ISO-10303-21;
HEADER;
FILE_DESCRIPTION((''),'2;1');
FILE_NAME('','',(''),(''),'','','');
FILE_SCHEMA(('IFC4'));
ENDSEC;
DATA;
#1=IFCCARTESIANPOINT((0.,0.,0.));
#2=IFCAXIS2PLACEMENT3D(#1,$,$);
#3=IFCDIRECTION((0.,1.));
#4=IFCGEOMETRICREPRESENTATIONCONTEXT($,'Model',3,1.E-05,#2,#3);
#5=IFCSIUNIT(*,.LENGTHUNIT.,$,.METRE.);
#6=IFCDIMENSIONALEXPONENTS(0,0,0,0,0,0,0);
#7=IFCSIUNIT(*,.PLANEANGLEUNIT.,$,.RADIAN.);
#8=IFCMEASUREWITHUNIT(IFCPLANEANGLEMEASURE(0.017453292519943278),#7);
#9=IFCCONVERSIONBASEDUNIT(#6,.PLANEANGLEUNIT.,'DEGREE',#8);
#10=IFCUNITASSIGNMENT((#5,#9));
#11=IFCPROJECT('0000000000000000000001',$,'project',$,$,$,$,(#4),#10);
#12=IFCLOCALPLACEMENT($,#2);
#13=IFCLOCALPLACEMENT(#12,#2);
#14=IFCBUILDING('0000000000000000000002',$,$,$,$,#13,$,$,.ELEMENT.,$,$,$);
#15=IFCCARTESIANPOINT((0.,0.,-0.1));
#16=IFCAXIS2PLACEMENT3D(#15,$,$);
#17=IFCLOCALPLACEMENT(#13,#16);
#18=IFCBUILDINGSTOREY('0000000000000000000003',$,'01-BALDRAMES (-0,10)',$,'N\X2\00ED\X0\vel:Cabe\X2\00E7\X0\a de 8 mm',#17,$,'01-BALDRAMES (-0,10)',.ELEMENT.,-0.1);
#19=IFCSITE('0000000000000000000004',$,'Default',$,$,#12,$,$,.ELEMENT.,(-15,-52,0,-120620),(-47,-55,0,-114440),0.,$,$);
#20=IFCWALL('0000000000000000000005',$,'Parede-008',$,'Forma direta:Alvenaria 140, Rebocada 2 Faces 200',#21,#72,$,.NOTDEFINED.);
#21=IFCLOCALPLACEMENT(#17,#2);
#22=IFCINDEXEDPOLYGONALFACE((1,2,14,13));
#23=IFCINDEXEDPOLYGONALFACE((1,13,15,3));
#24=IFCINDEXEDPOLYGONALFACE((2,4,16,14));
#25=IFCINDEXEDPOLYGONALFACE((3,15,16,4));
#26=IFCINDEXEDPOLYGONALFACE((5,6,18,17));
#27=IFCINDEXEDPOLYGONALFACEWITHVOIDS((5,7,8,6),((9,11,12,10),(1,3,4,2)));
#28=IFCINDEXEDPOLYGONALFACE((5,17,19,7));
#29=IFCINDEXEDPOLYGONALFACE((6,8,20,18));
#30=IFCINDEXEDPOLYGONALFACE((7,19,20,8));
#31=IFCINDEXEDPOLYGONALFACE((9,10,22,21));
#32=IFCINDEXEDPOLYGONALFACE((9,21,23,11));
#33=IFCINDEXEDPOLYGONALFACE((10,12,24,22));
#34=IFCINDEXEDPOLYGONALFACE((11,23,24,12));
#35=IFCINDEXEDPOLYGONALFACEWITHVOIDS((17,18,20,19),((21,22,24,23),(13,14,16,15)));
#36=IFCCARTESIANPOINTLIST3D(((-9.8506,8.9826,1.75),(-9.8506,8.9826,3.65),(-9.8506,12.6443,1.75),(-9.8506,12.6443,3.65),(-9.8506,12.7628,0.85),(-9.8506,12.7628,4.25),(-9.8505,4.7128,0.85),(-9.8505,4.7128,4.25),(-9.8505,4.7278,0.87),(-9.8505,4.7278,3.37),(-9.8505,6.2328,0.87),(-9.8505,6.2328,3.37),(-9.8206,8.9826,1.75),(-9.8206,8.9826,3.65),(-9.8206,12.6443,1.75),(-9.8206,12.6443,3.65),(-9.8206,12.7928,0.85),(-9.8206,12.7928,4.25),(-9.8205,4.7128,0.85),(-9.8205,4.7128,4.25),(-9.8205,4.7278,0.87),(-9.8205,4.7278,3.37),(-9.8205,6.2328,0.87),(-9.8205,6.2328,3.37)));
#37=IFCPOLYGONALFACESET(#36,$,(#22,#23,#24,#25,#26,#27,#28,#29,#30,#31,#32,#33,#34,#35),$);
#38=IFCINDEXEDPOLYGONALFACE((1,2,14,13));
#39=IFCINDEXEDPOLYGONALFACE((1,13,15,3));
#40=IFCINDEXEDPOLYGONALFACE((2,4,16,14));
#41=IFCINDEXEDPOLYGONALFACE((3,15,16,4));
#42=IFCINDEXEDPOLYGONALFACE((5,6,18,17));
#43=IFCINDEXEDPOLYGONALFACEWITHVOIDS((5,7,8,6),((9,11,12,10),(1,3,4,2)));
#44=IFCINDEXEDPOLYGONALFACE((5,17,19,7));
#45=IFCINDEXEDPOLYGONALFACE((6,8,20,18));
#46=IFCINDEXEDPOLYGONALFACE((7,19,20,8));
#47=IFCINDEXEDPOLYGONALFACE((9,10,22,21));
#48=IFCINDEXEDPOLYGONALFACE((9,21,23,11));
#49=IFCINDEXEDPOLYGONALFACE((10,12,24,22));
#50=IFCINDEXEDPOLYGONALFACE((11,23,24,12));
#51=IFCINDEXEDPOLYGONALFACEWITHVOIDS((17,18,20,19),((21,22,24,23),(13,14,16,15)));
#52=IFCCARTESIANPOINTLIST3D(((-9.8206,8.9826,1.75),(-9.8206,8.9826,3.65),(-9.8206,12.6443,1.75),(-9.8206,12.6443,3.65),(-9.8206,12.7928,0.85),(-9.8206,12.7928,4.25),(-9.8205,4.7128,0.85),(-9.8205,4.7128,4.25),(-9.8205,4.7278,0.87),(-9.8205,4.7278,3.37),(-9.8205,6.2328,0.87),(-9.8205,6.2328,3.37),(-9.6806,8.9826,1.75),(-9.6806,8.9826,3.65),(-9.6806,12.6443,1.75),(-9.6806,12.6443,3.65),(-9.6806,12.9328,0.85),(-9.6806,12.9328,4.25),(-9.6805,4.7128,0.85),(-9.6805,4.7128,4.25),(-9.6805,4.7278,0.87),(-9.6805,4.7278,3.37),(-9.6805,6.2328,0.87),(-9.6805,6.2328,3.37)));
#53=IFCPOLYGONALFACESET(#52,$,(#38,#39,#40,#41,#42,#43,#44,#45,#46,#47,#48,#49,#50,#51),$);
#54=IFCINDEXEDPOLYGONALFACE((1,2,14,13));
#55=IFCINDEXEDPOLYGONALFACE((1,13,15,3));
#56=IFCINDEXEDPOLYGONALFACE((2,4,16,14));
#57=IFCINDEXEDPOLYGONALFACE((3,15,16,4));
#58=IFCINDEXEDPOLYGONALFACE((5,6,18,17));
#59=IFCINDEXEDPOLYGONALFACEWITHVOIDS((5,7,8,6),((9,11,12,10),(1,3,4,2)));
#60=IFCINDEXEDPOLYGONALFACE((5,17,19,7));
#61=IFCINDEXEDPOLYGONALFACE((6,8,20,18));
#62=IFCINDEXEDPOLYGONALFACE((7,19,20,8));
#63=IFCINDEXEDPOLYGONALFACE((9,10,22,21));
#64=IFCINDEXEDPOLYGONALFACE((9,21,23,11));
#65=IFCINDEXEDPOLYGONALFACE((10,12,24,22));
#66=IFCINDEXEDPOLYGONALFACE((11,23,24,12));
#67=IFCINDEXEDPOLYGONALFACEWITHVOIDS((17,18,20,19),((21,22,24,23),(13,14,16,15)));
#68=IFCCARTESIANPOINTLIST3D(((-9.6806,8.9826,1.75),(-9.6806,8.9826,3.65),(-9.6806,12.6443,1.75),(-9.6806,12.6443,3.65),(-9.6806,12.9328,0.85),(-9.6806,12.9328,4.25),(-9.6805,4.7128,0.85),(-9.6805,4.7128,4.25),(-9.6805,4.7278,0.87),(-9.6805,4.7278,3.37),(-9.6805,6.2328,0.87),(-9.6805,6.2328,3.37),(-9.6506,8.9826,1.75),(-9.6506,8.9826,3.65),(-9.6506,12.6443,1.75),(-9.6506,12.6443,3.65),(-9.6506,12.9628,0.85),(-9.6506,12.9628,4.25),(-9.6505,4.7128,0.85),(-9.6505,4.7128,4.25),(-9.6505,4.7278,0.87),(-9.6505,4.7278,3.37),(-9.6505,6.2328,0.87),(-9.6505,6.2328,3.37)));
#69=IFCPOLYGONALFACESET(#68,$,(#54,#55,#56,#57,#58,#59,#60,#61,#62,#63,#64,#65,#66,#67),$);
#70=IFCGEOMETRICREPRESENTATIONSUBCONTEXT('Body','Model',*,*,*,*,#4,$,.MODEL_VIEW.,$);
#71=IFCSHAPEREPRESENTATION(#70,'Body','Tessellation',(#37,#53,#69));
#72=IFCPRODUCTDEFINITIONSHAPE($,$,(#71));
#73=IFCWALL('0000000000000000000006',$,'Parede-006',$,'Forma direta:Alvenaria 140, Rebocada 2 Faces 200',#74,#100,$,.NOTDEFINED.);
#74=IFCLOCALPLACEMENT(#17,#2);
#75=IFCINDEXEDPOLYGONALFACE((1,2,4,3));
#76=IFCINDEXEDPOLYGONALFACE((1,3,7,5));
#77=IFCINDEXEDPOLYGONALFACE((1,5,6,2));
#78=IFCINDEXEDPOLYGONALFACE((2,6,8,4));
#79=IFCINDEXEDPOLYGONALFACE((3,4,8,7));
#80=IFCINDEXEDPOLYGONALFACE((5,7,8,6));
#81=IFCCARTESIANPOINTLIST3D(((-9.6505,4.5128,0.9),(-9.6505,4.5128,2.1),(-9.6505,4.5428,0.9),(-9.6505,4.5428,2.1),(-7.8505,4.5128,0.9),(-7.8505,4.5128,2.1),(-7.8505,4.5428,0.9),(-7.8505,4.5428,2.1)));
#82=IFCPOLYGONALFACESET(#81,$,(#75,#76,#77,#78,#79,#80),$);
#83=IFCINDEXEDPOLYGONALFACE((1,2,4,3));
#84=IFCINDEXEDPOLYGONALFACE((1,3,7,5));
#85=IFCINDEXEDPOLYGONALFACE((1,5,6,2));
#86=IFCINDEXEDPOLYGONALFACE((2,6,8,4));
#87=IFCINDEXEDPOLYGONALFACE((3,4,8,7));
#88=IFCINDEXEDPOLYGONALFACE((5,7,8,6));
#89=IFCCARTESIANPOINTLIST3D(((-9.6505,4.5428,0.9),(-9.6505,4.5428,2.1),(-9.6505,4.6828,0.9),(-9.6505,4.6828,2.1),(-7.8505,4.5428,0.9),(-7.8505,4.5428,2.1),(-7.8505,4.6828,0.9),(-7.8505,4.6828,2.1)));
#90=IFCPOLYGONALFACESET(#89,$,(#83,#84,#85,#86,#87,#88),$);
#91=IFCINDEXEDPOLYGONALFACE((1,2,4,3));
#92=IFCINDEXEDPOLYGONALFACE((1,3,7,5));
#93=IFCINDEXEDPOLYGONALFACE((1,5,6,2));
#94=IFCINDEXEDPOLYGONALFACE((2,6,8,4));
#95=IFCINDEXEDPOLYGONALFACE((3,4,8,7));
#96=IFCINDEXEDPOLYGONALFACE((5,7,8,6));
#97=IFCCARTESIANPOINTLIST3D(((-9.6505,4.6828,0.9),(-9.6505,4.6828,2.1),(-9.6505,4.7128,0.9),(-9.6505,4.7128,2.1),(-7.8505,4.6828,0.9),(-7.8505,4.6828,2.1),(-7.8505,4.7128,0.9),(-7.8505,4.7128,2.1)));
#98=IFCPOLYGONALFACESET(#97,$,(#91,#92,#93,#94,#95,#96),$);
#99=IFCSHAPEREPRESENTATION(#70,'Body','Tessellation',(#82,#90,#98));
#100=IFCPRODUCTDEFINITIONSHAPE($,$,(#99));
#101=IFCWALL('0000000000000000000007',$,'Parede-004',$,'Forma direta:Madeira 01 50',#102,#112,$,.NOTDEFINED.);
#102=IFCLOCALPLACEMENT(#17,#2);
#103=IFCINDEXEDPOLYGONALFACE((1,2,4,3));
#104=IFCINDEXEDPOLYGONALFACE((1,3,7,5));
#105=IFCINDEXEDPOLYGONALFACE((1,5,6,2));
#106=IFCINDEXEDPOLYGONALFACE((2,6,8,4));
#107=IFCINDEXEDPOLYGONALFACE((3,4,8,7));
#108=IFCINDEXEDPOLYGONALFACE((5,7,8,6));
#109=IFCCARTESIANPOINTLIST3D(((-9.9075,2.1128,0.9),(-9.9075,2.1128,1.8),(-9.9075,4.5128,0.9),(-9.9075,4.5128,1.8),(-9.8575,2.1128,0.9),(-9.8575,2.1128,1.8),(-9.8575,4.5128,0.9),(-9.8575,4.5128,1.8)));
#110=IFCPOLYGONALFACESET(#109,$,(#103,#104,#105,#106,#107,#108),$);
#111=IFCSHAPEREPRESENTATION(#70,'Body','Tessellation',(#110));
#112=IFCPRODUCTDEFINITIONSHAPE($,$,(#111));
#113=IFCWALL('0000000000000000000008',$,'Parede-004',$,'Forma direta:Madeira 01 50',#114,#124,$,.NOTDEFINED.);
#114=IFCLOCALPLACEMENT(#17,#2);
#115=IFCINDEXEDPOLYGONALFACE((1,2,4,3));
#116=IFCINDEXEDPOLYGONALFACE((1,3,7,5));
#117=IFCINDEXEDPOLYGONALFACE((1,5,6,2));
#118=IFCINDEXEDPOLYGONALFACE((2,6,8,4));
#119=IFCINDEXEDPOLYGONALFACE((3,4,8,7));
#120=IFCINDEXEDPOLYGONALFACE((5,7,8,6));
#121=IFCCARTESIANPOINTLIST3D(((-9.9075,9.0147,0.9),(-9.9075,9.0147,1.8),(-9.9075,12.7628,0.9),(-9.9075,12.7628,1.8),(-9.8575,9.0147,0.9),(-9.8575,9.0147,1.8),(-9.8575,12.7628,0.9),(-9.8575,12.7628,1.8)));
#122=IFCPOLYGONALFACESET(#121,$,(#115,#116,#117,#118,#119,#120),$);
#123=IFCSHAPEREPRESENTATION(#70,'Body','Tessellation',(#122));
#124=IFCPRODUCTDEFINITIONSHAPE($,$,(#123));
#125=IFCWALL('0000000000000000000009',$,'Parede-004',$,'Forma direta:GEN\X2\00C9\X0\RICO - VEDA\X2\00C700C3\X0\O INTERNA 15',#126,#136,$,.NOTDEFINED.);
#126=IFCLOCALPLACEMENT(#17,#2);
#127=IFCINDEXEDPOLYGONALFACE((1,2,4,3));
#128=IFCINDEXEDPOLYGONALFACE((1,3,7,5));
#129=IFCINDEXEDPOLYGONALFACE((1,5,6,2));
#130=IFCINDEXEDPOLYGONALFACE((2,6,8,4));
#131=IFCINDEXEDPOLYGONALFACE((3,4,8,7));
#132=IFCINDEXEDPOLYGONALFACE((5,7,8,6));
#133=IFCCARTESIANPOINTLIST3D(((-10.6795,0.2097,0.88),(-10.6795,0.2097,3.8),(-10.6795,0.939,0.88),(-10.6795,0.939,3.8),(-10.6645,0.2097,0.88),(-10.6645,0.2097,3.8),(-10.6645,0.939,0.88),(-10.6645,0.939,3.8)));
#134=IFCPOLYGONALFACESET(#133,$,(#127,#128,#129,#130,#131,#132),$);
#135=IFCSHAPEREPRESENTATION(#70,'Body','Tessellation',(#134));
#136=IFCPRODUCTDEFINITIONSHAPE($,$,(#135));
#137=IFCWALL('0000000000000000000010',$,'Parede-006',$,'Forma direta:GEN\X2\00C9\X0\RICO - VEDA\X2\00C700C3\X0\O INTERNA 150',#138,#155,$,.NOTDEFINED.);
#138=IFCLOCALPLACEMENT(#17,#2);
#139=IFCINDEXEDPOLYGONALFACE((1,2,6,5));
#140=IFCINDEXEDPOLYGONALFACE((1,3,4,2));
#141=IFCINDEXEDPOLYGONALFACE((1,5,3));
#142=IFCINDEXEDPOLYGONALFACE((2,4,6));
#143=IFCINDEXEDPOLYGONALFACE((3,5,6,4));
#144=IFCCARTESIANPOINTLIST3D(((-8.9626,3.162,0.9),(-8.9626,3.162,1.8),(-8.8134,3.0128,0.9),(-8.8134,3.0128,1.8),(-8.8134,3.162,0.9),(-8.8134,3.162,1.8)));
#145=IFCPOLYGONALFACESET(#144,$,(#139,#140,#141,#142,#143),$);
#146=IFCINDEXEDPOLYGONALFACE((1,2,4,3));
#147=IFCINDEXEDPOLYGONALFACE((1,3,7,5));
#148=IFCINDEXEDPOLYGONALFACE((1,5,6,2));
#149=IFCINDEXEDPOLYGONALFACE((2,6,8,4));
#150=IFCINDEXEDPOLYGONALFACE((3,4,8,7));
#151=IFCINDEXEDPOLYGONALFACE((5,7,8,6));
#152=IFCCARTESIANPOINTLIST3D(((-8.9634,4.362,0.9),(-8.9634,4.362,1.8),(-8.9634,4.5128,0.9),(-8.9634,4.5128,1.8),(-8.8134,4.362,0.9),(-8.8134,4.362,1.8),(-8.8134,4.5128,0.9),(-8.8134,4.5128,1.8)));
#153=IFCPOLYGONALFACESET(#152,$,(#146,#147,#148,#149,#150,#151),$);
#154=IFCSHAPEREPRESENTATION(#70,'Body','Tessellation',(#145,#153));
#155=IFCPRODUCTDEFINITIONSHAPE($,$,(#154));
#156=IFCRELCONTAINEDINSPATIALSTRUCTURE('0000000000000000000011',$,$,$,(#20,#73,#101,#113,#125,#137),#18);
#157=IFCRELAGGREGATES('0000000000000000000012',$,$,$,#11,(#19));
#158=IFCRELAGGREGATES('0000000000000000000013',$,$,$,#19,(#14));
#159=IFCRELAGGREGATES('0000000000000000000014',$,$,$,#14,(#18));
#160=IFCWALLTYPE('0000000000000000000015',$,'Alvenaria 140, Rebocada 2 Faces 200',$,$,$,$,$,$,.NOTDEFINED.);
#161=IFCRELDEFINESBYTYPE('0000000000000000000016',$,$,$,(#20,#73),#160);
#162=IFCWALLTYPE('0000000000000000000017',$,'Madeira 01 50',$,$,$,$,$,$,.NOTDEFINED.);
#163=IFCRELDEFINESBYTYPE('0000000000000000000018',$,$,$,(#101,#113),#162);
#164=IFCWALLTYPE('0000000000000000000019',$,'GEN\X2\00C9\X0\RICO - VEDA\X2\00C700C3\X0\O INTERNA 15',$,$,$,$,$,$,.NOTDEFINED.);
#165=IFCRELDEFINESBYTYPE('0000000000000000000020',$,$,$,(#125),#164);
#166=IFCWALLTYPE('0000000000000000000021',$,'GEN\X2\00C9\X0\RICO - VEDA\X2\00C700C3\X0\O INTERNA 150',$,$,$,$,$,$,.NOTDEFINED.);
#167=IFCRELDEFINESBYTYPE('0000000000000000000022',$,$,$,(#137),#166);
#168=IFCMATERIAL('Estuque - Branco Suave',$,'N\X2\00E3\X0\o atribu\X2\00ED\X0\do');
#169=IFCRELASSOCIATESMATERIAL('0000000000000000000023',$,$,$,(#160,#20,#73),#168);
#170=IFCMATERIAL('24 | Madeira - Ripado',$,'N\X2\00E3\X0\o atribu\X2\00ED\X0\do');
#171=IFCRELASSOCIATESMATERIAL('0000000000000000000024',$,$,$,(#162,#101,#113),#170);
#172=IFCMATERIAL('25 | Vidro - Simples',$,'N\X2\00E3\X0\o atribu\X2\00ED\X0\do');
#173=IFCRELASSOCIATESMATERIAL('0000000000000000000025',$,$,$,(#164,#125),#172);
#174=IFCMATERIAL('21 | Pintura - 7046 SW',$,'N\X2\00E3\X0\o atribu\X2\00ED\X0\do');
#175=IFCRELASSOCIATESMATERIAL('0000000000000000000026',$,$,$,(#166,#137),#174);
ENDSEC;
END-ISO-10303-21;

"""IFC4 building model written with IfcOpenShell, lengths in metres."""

from ifc_helpers import new_model, entity, si_unit, converted_unit, direction, frame, origin, place, context, subcontext, project, spatial, indexed_curve, outline, extrude, material, type_object, element, save


model = new_model("IFC4")

# Units and contexts
model_context = context("Model", 3, precision=1e-05, world=origin(), true_north=direction((0.0, 1.0)))
body_context = subcontext(model_context, "Body", "Model", "MODEL_VIEW")
ifc_project = project(units=[si_unit("LENGTHUNIT", "METRE"), converted_unit("PLANEANGLEUNIT", "DEGREE", entity("IfcPlaneAngleMeasure", 0.017453292519943278), si_unit("PLANEANGLEUNIT", "RADIAN"), dimensions=[0, 0, 0, 0, 0, 0, 0])], contexts=[model_context])

# Site, building, storey
site_placement = place(None, origin())
site = spatial("IfcSite", under=ifc_project, at=site_placement, Name="Default", CompositionType="ELEMENT", RefLatitude=(-15, -52, 0, -120620), RefLongitude=(-47, -55, 0, -114440), RefElevation=0.0)
building_placement = place(site_placement, origin())
building = spatial("IfcBuilding", under=site, at=building_placement, CompositionType="ELEMENT")
storey_placement = place(building_placement, frame((0.0, 0.0, -0.1)))
storey = spatial("IfcBuildingStorey", under=building, at=storey_placement, Name="01-BALDRAMES (-0,10)", ObjectType="Nível:Cabeça de 8 mm", LongName="01-BALDRAMES (-0,10)", CompositionType="ELEMENT", Elevation=-0.1)

# Wall, openings
ifc_material_1 = material(Name="Estuque - Branco Suave", Category="Não atribuído")
wall_type_1 = type_object("IfcWallType", Name="Alvenaria 140, Rebocada 2 Faces 200", PredefinedType="NOTDEFINED", material=ifc_material_1)
wall_1_placement = place(storey_placement, frame((-9.8506, 4.7128, 0.85), z_axis=(0.0, 0.0, 1.0), x_axis=(0.0, 1.0, 0.0)))
wall_1 = element("IfcWall", 1, at=wall_1_placement, inside=storey, type_object=wall_type_1, material=ifc_material_1, Name="Parede-008", ObjectType="Forma direta:Alvenaria 140, Rebocada 2 Faces 200", PredefinedType="NOTDEFINED", context=body_context, shape_type="SweptSolid", body=[
    extrude(outline(indexed_curve([(-2.8726, -2.8514), (-2.8302, -2.8514), (2.862, 2.8408), (2.8408, 2.862), (-2.8726, -2.8514)], self_intersect=False)), frame((4.0325, -0.015, 0.0), z_axis=(0.0, 0.0, 1.0), x_axis=(-0.70711, 0.707104, 0.0)), (0.0, 0.0, 1.0), 3.4),
    extrude(outline(indexed_curve([(-0.0699, -4.075), (0.0701, -4.075), (0.0699, 4.145), (-0.0701, 4.005), (-0.0699, -4.075)], self_intersect=False)), frame((4.075, -0.1, 0.0), z_axis=(0.0, 0.0, 1.0), x_axis=(-0.000013, -1.0, 0.0)), (0.0, 0.0, 1.0), 3.4),
    extrude(outline(indexed_curve([(-0.0149, -4.1175), (0.0151, -4.1175), (0.0149, 4.1325), (-0.0151, 4.1025), (-0.0149, -4.1175)], self_intersect=False)), frame((4.1175, -0.185, 0.0), z_axis=(0.0, 0.0, 1.0), x_axis=(-0.000013, -1.0, 0.0)), (0.0, 0.0, 1.0), 3.4),
])
opening_1_placement = place(storey_placement, frame((-9.8506, 4.7128, 0.85), z_axis=(0.0, 0.0, 1.0), x_axis=(0.0, 1.0, 0.0)))
element("IfcOpeningElement", 2, at=opening_1_placement, cuts=wall_1, PredefinedType="OPENING", context=body_context, shape_type="SweptSolid", body=[
    extrude(outline(indexed_curve([(-0.95, -1.8308), (0.95, -1.8308), (0.95, 1.8308), (-0.95, 1.8308), (-0.95, -1.8308)], self_intersect=False)), frame((6.1006, -0.2, 1.85), z_axis=(-0.000006, 1.0, 0.0), x_axis=(0.0, 0.0, -1.0)), (0.0, 0.0, 1.0), 0.03),
])
opening_2_placement = place(storey_placement, frame((-9.8506, 4.7128, 0.85), z_axis=(0.0, 0.0, 1.0), x_axis=(0.0, 1.0, 0.0)))
element("IfcOpeningElement", 3, at=opening_2_placement, cuts=wall_1, PredefinedType="OPENING", context=body_context, shape_type="SweptSolid", body=[
    extrude(outline(indexed_curve([(-1.25, -0.7525), (1.25, -0.7525), (1.25, 0.7525), (-1.25, 0.7525), (-1.25, -0.7525)], self_intersect=False)), frame((0.7675, -0.2, 1.27), z_axis=(-0.000006, 1.0, 0.0), x_axis=(0.0, 0.0, 1.0)), (0.0, 0.0, 1.0), 0.03),
])
opening_3_placement = place(storey_placement, frame((-9.8506, 4.7128, 0.85), z_axis=(0.0, 0.0, 1.0), x_axis=(0.0, 1.0, 0.0)))
element("IfcOpeningElement", 4, at=opening_3_placement, cuts=wall_1, PredefinedType="OPENING", context=body_context, shape_type="SweptSolid", body=[
    extrude(outline(indexed_curve([(-1.25, -0.7525), (1.25, -0.7525), (1.25, 0.7525), (-1.25, 0.7525), (-1.25, -0.7525)], self_intersect=False)), frame((0.7675, -0.17, 1.27), z_axis=(-0.000006, 1.0, 0.0), x_axis=(0.0, 0.0, -1.0)), (0.0, 0.0, 1.0), 0.14),
])
opening_4_placement = place(storey_placement, frame((-9.8506, 4.7128, 0.85), z_axis=(0.0, 0.0, 1.0), x_axis=(0.0, 1.0, 0.0)))
element("IfcOpeningElement", 5, at=opening_4_placement, cuts=wall_1, PredefinedType="OPENING", context=body_context, shape_type="SweptSolid", body=[
    extrude(outline(indexed_curve([(-0.95, -1.8308), (0.95, -1.8308), (0.95, 1.8308), (-0.95, 1.8308), (-0.95, -1.8308)], self_intersect=False)), frame((6.1006, -0.17, 1.85), z_axis=(-0.000006, 1.0, 0.0), x_axis=(0.0, 0.0, 1.0)), (0.0, 0.0, 1.0), 0.14),
])
opening_5_placement = place(storey_placement, frame((-9.8506, 4.7128, 0.85), z_axis=(0.0, 0.0, 1.0), x_axis=(0.0, 1.0, 0.0)))
element("IfcOpeningElement", 6, at=opening_5_placement, cuts=wall_1, PredefinedType="OPENING", context=body_context, shape_type="SweptSolid", body=[
    extrude(outline(indexed_curve([(-0.95, -1.8308), (0.95, -1.8308), (0.95, 1.8308), (-0.95, 1.8308), (-0.95, -1.8308)], self_intersect=False)), frame((6.1006, 0.0, 1.85), z_axis=(0.000006, -1.0, 0.0), x_axis=(0.0, 0.0, 1.0)), (0.0, 0.0, 1.0), 0.03),
])
opening_6_placement = place(storey_placement, frame((-9.8506, 4.7128, 0.85), z_axis=(0.0, 0.0, 1.0), x_axis=(0.0, 1.0, 0.0)))
element("IfcOpeningElement", 7, at=opening_6_placement, cuts=wall_1, PredefinedType="OPENING", context=body_context, shape_type="SweptSolid", body=[
    extrude(outline(indexed_curve([(-1.25, -0.7525), (1.25, -0.7525), (1.25, 0.7525), (-1.25, 0.7525), (-1.25, -0.7525)], self_intersect=False)), frame((0.7675, 0.0, 1.27), z_axis=(0.000006, -1.0, 0.0), x_axis=(0.0, 0.0, -1.0)), (0.0, 0.0, 1.0), 0.03),
])

# Walls
wall_2_placement = place(storey_placement, frame((-9.6505, 4.5128, 0.9)))
element("IfcWall", 8, at=wall_2_placement, inside=storey, type_object=wall_type_1, material=ifc_material_1, Name="Parede-006", ObjectType="Forma direta:Alvenaria 140, Rebocada 2 Faces 200", PredefinedType="NOTDEFINED", context=body_context, shape_type="SweptSolid", body=[
    extrude(outline(indexed_curve([(-0.015, -0.9), (0.015, -0.9), (0.015, 0.9), (-0.015, 0.9), (-0.015, -0.9)], self_intersect=False)), frame((0.9, 0.015, 0.0), z_axis=(0.0, 0.0, 1.0), x_axis=(0.000007, -1.0, 0.0)), (0.0, 0.0, 1.0), 1.2),
    extrude(outline(indexed_curve([(-0.07, -0.9), (0.07, -0.9), (0.07, 0.9), (-0.07, 0.9), (-0.07, -0.9)], self_intersect=False)), frame((0.9, 0.1, 0.0), z_axis=(0.0, 0.0, 1.0), x_axis=(0.000011, 1.0, 0.0)), (0.0, 0.0, 1.0), 1.2),
    extrude(outline(indexed_curve([(-0.015, -0.9), (0.015, -0.9), (0.015, 0.9), (-0.015, 0.9), (-0.015, -0.9)], self_intersect=False)), frame((0.9, 0.185, 0.0), z_axis=(0.0, 0.0, 1.0), x_axis=(0.000011, 1.0, 0.0)), (0.0, 0.0, 1.0), 1.2),
])
ifc_material_2 = material(Name="24 | Madeira - Ripado", Category="Não atribuído")
wall_type_2 = type_object("IfcWallType", Name="Madeira 01 50", PredefinedType="NOTDEFINED", material=ifc_material_2)
wall_3_placement = place(storey_placement, frame((-9.9075, 2.1128, 0.9), z_axis=(0.0, 0.0, 1.0), x_axis=(0.0, 1.0, 0.0)))
element("IfcWall", 9, at=wall_3_placement, inside=storey, type_object=wall_type_2, material=ifc_material_2, Name="Parede-004", ObjectType="Forma direta:Madeira 01 50", PredefinedType="NOTDEFINED", context=body_context, shape_type="SweptSolid", body=[
    extrude(outline(indexed_curve([(-0.025, -1.2), (0.025, -1.2), (0.025, 1.2), (-0.025, 1.2), (-0.025, -1.2)], self_intersect=False)), frame((1.2, -0.025, 0.0), z_axis=(0.0, 0.0, 1.0), x_axis=(0.000007, 1.0, 0.0)), (0.0, 0.0, 1.0), 0.9),
])
wall_4_placement = place(storey_placement, frame((-9.9075, 9.0147, 0.9), z_axis=(0.0, 0.0, 1.0), x_axis=(0.0, 1.0, 0.0)))
element("IfcWall", 10, at=wall_4_placement, inside=storey, type_object=wall_type_2, material=ifc_material_2, Name="Parede-004", ObjectType="Forma direta:Madeira 01 50", PredefinedType="NOTDEFINED", context=body_context, shape_type="SweptSolid", body=[
    extrude(outline(indexed_curve([(-0.025, -1.8741), (0.025, -1.8741), (0.025, 1.8741), (-0.025, 1.8741), (-0.025, -1.8741)], self_intersect=False)), frame((1.8741, -0.025, 0.0), z_axis=(0.0, 0.0, 1.0), x_axis=(0.000013, 1.0, 0.0)), (0.0, 0.0, 1.0), 0.9),
])
ifc_material_3 = material(Name="25 | Vidro - Simples", Category="Não atribuído")
wall_type_3 = type_object("IfcWallType", Name="GENÉRICO - VEDAÇÃO INTERNA 15", PredefinedType="NOTDEFINED", material=ifc_material_3)
wall_5_placement = place(storey_placement, frame((-10.6795, 0.2097, 0.88), z_axis=(0.0, 0.0, 1.0), x_axis=(0.0, 1.0, 0.0)))
element("IfcWall", 11, at=wall_5_placement, inside=storey, type_object=wall_type_3, material=ifc_material_3, Name="Parede-004", ObjectType="Forma direta:GENÉRICO - VEDAÇÃO INTERNA 15", PredefinedType="NOTDEFINED", context=body_context, shape_type="SweptSolid", body=[
    extrude(outline(indexed_curve([(-0.0075, -0.3647), (0.0075, -0.3647), (0.0075, 0.3647), (-0.0075, 0.3647), (-0.0075, -0.3647)], self_intersect=False)), frame((0.3647, -0.0075, 0.0), z_axis=(0.0, 0.0, 1.0), x_axis=(0.000047, 1.0, 0.0)), (0.0, 0.0, 1.0), 2.92),
])
ifc_material_4 = material(Name="21 | Pintura - 7046 SW", Category="Não atribuído")
wall_type_4 = type_object("IfcWallType", Name="GENÉRICO - VEDAÇÃO INTERNA 150", PredefinedType="NOTDEFINED", material=ifc_material_4)
wall_6_placement = place(storey_placement, frame((-8.9634, 3.0128, 0.9), z_axis=(0.0, 0.0, 1.0), x_axis=(0.0, 1.0, 0.0)))
element("IfcWall", 12, at=wall_6_placement, inside=storey, type_object=wall_type_4, material=ifc_material_4, Name="Parede-006", ObjectType="Forma direta:GENÉRICO - VEDAÇÃO INTERNA 150", PredefinedType="NOTDEFINED", context=body_context, shape_type="SweptSolid", body=[
    extrude(outline(indexed_curve([(-0.1055, -0.0352), (0.1055, -0.0352), (0.0, 0.0703), (-0.1055, -0.0352)], self_intersect=False)), frame((0.0995, -0.1003, 0.0), z_axis=(0.0, 0.0, 1.0), x_axis=(-0.707104, -0.70711, 0.0)), (0.0, 0.0, 1.0), 0.9),
    extrude(outline(indexed_curve([(-0.0754, -0.075), (0.0754, -0.075), (0.0754, 0.075), (-0.0754, 0.075), (-0.0754, -0.075)], self_intersect=False)), frame((1.4246, -0.075, 0.0)), (0.0, 0.0, 1.0), 0.9),
])

save(model, "model.ifc")
